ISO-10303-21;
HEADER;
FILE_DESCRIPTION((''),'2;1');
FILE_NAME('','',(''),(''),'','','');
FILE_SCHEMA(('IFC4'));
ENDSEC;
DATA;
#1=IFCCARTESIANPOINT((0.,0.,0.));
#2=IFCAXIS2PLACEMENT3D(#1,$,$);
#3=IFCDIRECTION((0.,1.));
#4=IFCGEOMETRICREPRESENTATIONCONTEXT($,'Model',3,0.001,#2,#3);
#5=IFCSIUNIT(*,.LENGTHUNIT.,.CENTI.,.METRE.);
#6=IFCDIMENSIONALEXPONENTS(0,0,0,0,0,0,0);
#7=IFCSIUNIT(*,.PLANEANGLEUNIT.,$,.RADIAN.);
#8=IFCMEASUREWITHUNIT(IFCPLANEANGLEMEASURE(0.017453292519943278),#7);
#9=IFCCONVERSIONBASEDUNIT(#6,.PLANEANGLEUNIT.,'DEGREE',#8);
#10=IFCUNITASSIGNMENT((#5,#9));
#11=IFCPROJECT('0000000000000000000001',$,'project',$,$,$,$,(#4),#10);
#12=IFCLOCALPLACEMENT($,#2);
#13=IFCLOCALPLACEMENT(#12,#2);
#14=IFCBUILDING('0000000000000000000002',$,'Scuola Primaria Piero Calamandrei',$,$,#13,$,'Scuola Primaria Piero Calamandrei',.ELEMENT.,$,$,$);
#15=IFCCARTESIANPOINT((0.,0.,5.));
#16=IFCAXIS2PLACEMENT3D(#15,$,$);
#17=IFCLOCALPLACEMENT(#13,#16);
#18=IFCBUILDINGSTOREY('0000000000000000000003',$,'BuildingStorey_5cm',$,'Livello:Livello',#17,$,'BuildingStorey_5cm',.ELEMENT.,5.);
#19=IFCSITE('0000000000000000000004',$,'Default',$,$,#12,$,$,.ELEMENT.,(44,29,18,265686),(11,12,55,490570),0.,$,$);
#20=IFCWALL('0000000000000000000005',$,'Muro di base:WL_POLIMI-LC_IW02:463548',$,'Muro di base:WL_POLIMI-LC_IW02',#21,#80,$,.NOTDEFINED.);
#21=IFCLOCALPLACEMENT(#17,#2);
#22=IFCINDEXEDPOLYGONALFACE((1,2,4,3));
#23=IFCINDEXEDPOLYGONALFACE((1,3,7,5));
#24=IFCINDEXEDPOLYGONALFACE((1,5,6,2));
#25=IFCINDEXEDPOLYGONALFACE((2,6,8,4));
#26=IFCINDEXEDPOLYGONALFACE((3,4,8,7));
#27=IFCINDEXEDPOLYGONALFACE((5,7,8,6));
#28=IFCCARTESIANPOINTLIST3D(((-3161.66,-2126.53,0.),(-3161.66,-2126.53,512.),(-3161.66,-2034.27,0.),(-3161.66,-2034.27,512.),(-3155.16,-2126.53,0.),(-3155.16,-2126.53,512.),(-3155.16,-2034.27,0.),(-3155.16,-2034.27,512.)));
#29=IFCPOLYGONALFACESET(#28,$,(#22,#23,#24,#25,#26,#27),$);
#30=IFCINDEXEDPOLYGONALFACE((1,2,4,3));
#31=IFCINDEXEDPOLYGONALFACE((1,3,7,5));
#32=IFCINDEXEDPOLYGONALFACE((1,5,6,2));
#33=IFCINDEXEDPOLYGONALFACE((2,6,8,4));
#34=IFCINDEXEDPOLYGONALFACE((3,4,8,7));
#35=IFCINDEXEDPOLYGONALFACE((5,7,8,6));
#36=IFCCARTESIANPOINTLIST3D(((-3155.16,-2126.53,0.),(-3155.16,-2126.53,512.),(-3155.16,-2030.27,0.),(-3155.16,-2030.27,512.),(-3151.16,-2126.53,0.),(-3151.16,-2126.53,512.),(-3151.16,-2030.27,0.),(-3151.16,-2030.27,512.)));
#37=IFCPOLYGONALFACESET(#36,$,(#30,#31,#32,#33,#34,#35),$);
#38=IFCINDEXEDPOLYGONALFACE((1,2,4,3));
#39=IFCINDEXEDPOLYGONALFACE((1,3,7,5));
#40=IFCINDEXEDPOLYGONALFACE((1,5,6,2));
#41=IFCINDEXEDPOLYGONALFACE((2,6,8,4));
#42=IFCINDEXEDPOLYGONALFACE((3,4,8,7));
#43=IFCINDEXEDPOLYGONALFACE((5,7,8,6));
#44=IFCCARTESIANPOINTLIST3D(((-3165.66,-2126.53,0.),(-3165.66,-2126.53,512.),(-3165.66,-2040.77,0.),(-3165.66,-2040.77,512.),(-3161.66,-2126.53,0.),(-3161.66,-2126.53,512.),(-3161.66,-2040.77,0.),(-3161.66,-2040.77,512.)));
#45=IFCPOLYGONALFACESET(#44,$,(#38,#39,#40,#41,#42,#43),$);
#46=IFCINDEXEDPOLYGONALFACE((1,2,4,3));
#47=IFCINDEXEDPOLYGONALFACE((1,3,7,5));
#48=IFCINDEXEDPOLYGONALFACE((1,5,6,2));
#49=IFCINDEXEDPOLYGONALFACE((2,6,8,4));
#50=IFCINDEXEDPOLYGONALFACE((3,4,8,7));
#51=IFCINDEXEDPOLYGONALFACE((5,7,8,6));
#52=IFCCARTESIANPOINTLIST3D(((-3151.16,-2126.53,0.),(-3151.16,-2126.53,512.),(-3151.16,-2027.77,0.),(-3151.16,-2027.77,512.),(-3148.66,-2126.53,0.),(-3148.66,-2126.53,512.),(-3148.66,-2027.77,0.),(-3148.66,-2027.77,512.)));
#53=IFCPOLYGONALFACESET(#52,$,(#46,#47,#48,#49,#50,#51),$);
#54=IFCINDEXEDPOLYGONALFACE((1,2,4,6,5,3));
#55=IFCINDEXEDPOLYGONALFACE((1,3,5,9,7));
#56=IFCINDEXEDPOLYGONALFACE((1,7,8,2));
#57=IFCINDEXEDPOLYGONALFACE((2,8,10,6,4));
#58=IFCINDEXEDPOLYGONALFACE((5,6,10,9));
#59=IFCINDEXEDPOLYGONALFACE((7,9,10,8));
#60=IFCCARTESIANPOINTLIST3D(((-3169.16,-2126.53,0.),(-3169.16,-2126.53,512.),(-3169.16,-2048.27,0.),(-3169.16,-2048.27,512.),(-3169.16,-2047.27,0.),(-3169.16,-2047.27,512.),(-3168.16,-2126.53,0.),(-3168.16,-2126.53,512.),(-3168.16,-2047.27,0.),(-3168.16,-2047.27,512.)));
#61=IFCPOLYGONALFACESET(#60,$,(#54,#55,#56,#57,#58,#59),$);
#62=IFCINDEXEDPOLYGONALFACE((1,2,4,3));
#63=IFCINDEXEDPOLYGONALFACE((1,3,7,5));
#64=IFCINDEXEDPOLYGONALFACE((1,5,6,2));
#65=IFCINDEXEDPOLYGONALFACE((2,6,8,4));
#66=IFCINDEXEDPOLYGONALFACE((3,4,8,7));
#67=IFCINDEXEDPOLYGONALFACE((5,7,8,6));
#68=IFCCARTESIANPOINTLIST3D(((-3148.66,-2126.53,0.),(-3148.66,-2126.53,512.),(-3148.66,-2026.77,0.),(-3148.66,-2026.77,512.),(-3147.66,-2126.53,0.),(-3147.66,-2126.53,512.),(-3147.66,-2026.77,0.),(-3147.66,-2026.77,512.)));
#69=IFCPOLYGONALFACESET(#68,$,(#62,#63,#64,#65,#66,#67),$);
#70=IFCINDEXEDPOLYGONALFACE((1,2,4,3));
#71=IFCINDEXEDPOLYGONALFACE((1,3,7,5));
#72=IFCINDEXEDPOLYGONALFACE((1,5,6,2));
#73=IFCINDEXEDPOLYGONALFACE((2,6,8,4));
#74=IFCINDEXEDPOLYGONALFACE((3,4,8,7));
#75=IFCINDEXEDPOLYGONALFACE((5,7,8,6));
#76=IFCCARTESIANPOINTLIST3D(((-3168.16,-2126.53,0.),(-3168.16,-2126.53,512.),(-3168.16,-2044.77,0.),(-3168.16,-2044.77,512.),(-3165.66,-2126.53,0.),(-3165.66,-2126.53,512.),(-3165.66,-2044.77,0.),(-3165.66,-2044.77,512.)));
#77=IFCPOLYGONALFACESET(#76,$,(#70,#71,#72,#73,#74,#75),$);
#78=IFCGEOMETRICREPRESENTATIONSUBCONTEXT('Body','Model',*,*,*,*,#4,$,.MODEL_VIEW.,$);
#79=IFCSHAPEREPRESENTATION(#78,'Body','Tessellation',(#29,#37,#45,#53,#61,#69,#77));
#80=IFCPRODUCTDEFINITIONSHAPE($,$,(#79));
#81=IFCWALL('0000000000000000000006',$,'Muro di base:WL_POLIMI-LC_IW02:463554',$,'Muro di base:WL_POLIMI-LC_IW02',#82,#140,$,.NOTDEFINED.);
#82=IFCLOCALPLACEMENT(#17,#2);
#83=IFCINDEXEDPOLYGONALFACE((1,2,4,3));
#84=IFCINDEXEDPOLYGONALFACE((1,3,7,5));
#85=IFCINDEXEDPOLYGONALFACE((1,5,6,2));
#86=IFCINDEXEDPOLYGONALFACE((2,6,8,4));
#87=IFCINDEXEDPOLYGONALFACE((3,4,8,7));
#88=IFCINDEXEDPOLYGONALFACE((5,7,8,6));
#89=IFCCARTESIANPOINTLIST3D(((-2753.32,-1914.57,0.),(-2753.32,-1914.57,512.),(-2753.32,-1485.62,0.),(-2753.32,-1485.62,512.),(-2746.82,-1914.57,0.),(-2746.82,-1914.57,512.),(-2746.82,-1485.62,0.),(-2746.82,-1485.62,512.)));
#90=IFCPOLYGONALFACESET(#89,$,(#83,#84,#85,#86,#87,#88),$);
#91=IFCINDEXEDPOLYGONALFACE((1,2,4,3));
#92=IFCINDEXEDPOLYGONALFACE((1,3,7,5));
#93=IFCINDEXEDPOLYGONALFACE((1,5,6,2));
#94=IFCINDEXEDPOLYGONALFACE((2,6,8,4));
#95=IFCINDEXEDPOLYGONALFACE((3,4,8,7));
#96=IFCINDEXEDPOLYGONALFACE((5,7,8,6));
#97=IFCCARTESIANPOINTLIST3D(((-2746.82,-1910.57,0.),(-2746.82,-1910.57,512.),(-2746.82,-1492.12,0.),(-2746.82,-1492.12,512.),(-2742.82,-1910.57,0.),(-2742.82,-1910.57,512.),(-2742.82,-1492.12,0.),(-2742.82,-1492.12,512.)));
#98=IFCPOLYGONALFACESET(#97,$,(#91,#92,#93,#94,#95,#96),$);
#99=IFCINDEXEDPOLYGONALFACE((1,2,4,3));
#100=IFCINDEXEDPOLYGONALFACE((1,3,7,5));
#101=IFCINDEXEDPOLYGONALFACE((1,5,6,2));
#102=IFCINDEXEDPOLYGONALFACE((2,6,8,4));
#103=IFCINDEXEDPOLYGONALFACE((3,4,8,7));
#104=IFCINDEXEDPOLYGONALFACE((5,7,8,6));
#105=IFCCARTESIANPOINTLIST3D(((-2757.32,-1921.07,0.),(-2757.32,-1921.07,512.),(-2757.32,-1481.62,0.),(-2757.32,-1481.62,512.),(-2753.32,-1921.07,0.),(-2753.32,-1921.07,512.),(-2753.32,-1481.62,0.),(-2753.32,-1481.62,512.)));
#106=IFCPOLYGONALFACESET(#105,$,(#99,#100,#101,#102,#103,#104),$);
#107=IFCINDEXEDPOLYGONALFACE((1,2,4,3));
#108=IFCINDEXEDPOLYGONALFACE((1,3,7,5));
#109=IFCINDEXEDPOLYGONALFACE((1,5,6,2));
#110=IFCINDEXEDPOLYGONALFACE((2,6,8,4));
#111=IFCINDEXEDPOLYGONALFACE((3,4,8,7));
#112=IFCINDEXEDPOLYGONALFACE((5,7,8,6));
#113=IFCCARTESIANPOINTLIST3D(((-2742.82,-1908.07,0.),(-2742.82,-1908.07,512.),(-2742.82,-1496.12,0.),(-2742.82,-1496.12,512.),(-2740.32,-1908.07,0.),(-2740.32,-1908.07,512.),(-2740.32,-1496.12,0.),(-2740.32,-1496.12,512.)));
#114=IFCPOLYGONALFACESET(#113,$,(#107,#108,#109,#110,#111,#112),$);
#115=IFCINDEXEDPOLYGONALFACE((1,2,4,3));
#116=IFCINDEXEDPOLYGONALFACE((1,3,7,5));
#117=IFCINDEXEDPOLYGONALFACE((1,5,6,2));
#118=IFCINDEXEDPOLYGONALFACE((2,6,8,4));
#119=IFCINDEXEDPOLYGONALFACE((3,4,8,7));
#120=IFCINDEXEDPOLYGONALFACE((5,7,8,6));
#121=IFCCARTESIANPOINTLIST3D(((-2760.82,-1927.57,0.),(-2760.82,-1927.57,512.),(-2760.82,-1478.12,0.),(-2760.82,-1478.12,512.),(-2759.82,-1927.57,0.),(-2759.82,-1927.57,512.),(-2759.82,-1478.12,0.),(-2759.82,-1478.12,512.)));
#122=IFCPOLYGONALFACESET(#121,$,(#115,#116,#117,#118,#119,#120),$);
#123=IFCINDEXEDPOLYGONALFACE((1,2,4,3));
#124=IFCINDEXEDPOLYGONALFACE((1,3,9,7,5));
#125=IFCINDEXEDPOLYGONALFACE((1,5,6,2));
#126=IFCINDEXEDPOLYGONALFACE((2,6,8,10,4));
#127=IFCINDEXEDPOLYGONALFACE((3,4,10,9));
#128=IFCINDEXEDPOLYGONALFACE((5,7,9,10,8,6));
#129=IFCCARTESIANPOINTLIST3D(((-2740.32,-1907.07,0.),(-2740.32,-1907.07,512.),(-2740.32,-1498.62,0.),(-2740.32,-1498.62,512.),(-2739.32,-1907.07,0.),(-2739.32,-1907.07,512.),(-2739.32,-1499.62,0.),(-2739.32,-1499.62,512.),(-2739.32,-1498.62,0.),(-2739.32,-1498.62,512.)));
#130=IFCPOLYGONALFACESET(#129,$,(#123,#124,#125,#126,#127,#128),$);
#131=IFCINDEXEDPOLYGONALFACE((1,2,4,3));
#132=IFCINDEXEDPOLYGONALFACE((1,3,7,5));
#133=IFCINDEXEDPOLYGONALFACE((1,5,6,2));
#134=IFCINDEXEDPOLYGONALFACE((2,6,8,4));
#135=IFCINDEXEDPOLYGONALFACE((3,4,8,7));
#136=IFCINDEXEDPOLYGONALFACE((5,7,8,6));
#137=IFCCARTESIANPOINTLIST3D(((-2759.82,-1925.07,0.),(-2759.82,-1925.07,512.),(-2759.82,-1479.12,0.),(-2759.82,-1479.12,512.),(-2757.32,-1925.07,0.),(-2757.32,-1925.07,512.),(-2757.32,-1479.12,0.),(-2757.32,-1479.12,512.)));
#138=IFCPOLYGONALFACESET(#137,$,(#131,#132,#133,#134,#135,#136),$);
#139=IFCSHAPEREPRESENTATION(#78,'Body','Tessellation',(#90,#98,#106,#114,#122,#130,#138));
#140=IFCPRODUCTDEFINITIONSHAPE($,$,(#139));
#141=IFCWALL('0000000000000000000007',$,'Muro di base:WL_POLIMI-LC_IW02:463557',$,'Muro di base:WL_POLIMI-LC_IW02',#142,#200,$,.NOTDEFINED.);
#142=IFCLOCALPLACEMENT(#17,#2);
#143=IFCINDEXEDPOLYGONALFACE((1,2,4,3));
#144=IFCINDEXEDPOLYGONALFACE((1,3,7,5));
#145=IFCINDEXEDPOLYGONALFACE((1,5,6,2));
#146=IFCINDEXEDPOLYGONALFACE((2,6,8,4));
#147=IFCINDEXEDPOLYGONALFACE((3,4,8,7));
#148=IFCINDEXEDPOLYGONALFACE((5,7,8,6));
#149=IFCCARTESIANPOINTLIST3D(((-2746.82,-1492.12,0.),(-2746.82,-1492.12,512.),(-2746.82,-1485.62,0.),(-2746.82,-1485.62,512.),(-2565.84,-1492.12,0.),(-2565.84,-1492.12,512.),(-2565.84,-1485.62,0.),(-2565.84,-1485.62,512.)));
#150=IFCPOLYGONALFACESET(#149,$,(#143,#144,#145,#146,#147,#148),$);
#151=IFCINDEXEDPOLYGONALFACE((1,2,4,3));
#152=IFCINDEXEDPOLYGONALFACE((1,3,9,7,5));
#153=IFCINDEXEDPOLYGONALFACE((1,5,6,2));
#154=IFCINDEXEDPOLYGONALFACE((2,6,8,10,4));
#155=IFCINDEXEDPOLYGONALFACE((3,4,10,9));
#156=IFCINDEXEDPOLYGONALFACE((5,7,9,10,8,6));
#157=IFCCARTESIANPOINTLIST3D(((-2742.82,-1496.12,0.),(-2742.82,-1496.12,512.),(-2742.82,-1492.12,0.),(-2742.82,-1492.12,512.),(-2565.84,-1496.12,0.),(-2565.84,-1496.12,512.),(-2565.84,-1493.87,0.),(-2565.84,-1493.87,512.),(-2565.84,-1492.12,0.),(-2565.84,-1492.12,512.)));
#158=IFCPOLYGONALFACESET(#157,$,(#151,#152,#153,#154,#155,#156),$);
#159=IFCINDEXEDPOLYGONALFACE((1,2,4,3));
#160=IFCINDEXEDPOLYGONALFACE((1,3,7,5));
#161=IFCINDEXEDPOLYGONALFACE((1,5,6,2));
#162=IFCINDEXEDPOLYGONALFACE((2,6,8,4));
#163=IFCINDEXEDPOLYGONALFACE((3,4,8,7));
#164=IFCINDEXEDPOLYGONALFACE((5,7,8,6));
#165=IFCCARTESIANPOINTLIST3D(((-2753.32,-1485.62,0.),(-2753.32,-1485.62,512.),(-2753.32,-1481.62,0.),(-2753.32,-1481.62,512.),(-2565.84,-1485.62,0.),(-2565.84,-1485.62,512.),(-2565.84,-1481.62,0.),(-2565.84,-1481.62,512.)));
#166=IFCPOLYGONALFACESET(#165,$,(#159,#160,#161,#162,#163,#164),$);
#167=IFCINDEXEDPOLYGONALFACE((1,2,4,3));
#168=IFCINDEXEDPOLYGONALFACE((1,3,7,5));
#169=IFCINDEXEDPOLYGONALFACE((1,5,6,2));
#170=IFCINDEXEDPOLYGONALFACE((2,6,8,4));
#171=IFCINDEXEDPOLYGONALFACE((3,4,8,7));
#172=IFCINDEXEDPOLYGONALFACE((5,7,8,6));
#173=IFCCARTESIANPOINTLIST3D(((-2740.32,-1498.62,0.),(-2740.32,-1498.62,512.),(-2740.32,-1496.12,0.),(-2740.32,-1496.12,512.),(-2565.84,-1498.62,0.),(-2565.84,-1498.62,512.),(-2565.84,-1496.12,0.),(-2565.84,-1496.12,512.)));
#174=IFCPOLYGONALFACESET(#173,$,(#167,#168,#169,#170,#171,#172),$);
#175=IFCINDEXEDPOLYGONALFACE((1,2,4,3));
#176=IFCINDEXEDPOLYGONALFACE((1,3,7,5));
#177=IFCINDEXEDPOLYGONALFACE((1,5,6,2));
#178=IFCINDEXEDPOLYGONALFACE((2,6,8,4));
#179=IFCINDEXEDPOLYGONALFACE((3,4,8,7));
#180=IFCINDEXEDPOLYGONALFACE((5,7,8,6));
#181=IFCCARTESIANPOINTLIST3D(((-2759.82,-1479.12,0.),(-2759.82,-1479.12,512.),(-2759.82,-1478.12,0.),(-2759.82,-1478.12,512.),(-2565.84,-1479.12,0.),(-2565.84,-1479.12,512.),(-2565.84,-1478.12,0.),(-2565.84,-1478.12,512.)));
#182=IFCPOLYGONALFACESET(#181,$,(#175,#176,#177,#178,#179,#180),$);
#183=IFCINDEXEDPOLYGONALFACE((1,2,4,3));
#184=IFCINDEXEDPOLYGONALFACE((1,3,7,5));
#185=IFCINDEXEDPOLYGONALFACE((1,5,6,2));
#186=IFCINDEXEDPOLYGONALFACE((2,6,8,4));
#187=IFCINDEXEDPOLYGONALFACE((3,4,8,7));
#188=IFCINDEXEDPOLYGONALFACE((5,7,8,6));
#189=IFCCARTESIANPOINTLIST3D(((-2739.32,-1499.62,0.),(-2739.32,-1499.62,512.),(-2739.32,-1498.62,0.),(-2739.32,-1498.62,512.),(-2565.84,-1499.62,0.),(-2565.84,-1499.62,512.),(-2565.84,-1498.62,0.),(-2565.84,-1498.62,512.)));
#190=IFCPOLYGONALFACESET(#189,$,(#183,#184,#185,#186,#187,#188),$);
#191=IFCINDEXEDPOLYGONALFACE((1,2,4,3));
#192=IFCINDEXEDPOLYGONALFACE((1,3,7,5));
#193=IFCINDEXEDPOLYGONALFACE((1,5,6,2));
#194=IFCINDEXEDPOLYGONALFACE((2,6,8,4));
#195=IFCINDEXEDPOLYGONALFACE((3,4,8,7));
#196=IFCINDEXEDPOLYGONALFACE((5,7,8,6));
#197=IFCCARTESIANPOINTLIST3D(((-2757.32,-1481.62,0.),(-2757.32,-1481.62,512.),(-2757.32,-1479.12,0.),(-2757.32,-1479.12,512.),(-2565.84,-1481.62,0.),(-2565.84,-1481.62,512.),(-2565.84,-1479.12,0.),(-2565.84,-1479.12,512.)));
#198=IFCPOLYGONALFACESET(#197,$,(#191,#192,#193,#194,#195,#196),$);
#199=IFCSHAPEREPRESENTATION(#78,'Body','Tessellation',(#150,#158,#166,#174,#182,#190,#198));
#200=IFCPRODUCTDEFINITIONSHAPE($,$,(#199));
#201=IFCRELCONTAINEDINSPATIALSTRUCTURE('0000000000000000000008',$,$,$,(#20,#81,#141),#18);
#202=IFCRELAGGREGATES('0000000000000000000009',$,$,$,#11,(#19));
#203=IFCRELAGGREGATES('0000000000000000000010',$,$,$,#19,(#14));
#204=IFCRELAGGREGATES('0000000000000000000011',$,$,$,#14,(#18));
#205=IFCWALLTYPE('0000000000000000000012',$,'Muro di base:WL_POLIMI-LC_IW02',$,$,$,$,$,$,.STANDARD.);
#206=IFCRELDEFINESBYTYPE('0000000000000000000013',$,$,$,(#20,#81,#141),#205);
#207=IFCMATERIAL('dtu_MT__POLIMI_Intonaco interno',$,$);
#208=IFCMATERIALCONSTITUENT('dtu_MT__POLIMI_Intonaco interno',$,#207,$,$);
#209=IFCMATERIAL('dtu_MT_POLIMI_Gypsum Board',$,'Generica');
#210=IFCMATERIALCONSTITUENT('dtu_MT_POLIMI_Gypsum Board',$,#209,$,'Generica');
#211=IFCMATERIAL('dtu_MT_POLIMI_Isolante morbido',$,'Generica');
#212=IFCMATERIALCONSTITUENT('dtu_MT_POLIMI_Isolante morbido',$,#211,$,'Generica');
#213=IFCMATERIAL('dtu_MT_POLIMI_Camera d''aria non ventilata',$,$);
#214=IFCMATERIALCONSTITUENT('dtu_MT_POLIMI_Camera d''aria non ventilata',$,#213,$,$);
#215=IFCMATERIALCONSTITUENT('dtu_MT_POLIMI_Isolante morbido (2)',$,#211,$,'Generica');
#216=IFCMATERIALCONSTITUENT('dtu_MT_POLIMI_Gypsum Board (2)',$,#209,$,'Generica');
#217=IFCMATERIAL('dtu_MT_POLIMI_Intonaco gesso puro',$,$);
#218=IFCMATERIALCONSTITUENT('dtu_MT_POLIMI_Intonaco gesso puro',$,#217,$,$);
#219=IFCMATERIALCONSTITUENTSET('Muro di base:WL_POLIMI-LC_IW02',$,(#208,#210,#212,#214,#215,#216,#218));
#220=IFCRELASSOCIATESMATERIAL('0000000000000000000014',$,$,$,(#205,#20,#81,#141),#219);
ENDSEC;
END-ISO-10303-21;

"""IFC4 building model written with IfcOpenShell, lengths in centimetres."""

from ifc_helpers import new_model, entity, si_unit, converted_unit, direction, frame, origin, place, context, subcontext, project, spatial, indexed_curve, outline, extrude, material, constituent, constituent_set, type_object, element, save


model = new_model("IFC4")

# Units and contexts
model_context = context("Model", 3, precision=0.001, world=origin(), true_north=direction((0.0, 1.0)))
body_context = subcontext(model_context, "Body", "Model", "MODEL_VIEW")
ifc_project = project(units=[si_unit("LENGTHUNIT", "METRE", prefix="CENTI"), converted_unit("PLANEANGLEUNIT", "DEGREE", entity("IfcPlaneAngleMeasure", 0.017453292519943278), si_unit("PLANEANGLEUNIT", "RADIAN"), dimensions=[0, 0, 0, 0, 0, 0, 0])], contexts=[model_context])

# Site, building, storey
site_placement = place(None, origin())
site = spatial("IfcSite", under=ifc_project, at=site_placement, Name="Default", CompositionType="ELEMENT", RefLatitude=(44, 29, 18, 265686), RefLongitude=(11, 12, 55, 490570), RefElevation=0.0)
building_placement = place(site_placement, origin())
building = spatial("IfcBuilding", under=site, at=building_placement, Name="Scuola Primaria Piero Calamandrei", LongName="Scuola Primaria Piero Calamandrei", CompositionType="ELEMENT")
storey_placement = place(building_placement, frame((0.0, 0.0, 5.0)))
storey = spatial("IfcBuildingStorey", under=building, at=storey_placement, Name="BuildingStorey_5cm", ObjectType="Livello:Livello", LongName="BuildingStorey_5cm", CompositionType="ELEMENT", Elevation=5.0)

# Shared definitions
ifc_material_1 = material(Name="dtu_MT_POLIMI_Intonaco gesso puro")

# Shared definitions
ifc_material_2 = material(Name="dtu_MT__POLIMI_Intonaco interno")

# Shared definitions
ifc_constituent_1 = constituent(ifc_material_2, Name="dtu_MT__POLIMI_Intonaco interno")
ifc_material_3 = material(Name="dtu_MT_POLIMI_Gypsum Board", Category="Generica")
ifc_constituent_2 = constituent(ifc_material_3, Name="dtu_MT_POLIMI_Gypsum Board", Category="Generica")
ifc_material_4 = material(Name="dtu_MT_POLIMI_Isolante morbido", Category="Generica")
ifc_constituent_3 = constituent(ifc_material_4, Name="dtu_MT_POLIMI_Isolante morbido", Category="Generica")
ifc_material_5 = material(Name="dtu_MT_POLIMI_Camera d'aria non ventilata")
ifc_constituent_4 = constituent(ifc_material_5, Name="dtu_MT_POLIMI_Camera d'aria non ventilata")
ifc_constituent_5 = constituent(ifc_material_4, Name="dtu_MT_POLIMI_Isolante morbido (2)", Category="Generica")
ifc_constituent_6 = constituent(ifc_material_3, Name="dtu_MT_POLIMI_Gypsum Board (2)", Category="Generica")
ifc_constituent_7 = constituent(ifc_material_1, Name="dtu_MT_POLIMI_Intonaco gesso puro")
ifc_constituent_set_1 = constituent_set(constituents=[ifc_constituent_1, ifc_constituent_2, ifc_constituent_3, ifc_constituent_4, ifc_constituent_5, ifc_constituent_6, ifc_constituent_7], Name="Muro di base:WL_POLIMI-LC_IW02")
wall_type_1 = type_object("IfcWallType", Name="Muro di base:WL_POLIMI-LC_IW02", PredefinedType="STANDARD", material=ifc_constituent_set_1)

# Wall
wall_1_placement = place(storey_placement, frame((-3158.41, -2026.77, 0.0), z_axis=(0.0, 0.0, 1.0), x_axis=(0.0, -1.0, 0.0)))
element("IfcWall", 1, at=wall_1_placement, inside=storey, type_object=wall_type_1, material=ifc_constituent_set_1, Name="Muro di base:WL_POLIMI-LC_IW02:463548", ObjectType="Muro di base:WL_POLIMI-LC_IW02", PredefinedType="NOTDEFINED", context=body_context, shape_type="SweptSolid", body=[
    extrude(outline(indexed_curve([(-46.13, -3.25), (46.13, -3.25), (46.13, 3.25), (-46.13, 3.25), (-46.13, -3.25)], self_intersect=False)), frame((53.63, 0.0, 0.0)), (0.0, 0.0, 1.0), 512.0),
    extrude(outline(indexed_curve([(-48.13, -2.0), (48.13, -2.0), (48.13, 2.0), (-48.13, 2.0), (-48.13, -2.0)], self_intersect=False)), frame((51.63, 5.25, 0.0)), (0.0, 0.0, 1.0), 512.0),
    extrude(outline(indexed_curve([(-42.88, -2.0), (42.88, -2.0), (42.88, 2.0), (-42.88, 2.0), (-42.88, -2.0)], self_intersect=False)), frame((56.88, -5.25, 0.0)), (0.0, 0.0, 1.0), 512.0),
    extrude(outline(indexed_curve([(-49.38, -1.25), (49.38, -1.25), (49.38, 1.25), (-49.38, 1.25), (-49.38, -1.25)], self_intersect=False)), frame((50.38, 8.5, 0.0)), (0.0, 0.0, 1.0), 512.0),
    extrude(outline(indexed_curve([(-30.9, -0.4), (47.35, -0.4), (47.35, 0.6), (-31.9, 0.6), (-31.9, -0.4), (-30.9, -0.4)], self_intersect=False)), frame((52.4, -10.35, 0.0)), (0.0, 0.0, 1.0), 512.0),
    extrude(outline(indexed_curve([(-0.5, -49.88), (0.5, -49.88), (0.5, 49.88), (-0.5, 49.88), (-0.5, -49.88)], self_intersect=False)), frame((49.88, 10.25, 0.0), z_axis=(0.0, 0.0, 1.0), x_axis=(0.0, -1.0, 0.0)), (0.0, 0.0, 1.0), 512.0),
    extrude(outline(indexed_curve([(-40.88, -1.25), (40.88, -1.25), (40.88, 1.25), (-40.88, 1.25), (-40.88, -1.25)], self_intersect=False)), frame((58.88, -8.5, 0.0)), (0.0, 0.0, 1.0), 512.0),
])

# Walls
wall_2_placement = place(storey_placement, frame((-2750.07, -1478.12, 0.0), z_axis=(0.0, 0.0, 1.0), x_axis=(0.0, -1.0, 0.0)))
element("IfcWall", 2, at=wall_2_placement, inside=storey, type_object=wall_type_1, material=ifc_constituent_set_1, Name="Muro di base:WL_POLIMI-LC_IW02:463554", ObjectType="Muro di base:WL_POLIMI-LC_IW02", PredefinedType="NOTDEFINED", context=body_context, shape_type="SweptSolid", body=[
    extrude(outline(indexed_curve([(-214.47, -3.25), (214.47, -3.25), (214.47, 3.25), (-214.47, 3.25), (-214.47, -3.25)], self_intersect=False)), frame((221.97, 0.0, 0.0)), (0.0, 0.0, 1.0), 512.0),
    extrude(outline(indexed_curve([(-209.22, -2.0), (209.22, -2.0), (209.22, 2.0), (-209.22, 2.0), (-209.22, -2.0)], self_intersect=False)), frame((223.22, 5.25, 0.0)), (0.0, 0.0, 1.0), 512.0),
    extrude(outline(indexed_curve([(-219.72, -2.0), (219.72, -2.0), (219.72, 2.0), (-219.72, 2.0), (-219.72, -2.0)], self_intersect=False)), frame((223.22, -5.25, 0.0)), (0.0, 0.0, 1.0), 512.0),
    extrude(outline(indexed_curve([(-205.97, -1.25), (205.97, -1.25), (205.97, 1.25), (-205.97, 1.25), (-205.97, -1.25)], self_intersect=False)), frame((223.97, 8.5, 0.0)), (0.0, 0.0, 1.0), 512.0),
    extrude(outline(indexed_curve([(-0.5, -224.72), (0.5, -224.72), (0.5, 224.72), (-0.5, 224.72), (-0.5, -224.72)], self_intersect=False)), frame((224.72, -10.25, 0.0), z_axis=(0.0, 0.0, 1.0), x_axis=(0.0, 1.0, 0.0)), (0.0, 0.0, 1.0), 512.0),
    extrude(outline(indexed_curve([(162.58, -0.4), (163.58, -0.4), (163.58, 0.6), (-244.87, 0.6), (-244.87, -0.4), (162.58, -0.4)], self_intersect=False)), frame((184.08, 10.35, 0.0), z_axis=(0.0, 0.0, 1.0), x_axis=(-1.0, 0.0, 0.0)), (0.0, 0.0, 1.0), 512.0),
    extrude(outline(indexed_curve([(-222.97, -1.25), (222.97, -1.25), (222.97, 1.25), (-222.97, 1.25), (-222.97, -1.25)], self_intersect=False)), frame((223.97, -8.5, 0.0)), (0.0, 0.0, 1.0), 512.0),
])
wall_3_placement = place(storey_placement, frame((-2565.84, -1488.87, 0.0), z_axis=(0.0, 0.0, 1.0), x_axis=(-1.0, 0.0, 0.0)))
element("IfcWall", 3, at=wall_3_placement, inside=storey, type_object=wall_type_1, material=ifc_constituent_set_1, Name="Muro di base:WL_POLIMI-LC_IW02:463557", ObjectType="Muro di base:WL_POLIMI-LC_IW02", PredefinedType="NOTDEFINED", context=body_context, shape_type="SweptSolid", body=[
    extrude(outline(indexed_curve([(-90.49, -3.25), (90.49, -3.25), (90.49, 3.25), (-90.49, 3.25), (-90.49, -3.25)], self_intersect=False)), frame((90.49, 0.0, 0.0)), (0.0, 0.0, 1.0), 512.0),
    extrude(outline(indexed_curve([(-70.79, -1.95), (106.19, -1.95), (106.19, 2.05), (-70.79, 2.05), (-70.79, -0.2), (-70.79, -1.95)], self_intersect=False)), frame((70.79, 5.2, 0.0)), (0.0, 0.0, 1.0), 512.0),
    extrude(outline(indexed_curve([(-93.74, -2.0), (93.74, -2.0), (93.74, 2.0), (-93.74, 2.0), (-93.74, -2.0)], self_intersect=False)), frame((93.74, -5.25, 0.0)), (0.0, 0.0, 1.0), 512.0),
    extrude(outline(indexed_curve([(-87.24, -1.25), (87.24, -1.25), (87.24, 1.25), (-87.24, 1.25), (-87.24, -1.25)], self_intersect=False)), frame((87.24, 8.5, 0.0)), (0.0, 0.0, 1.0), 512.0),
    extrude(outline(indexed_curve([(-0.5, -96.99), (0.5, -96.99), (0.5, 96.99), (-0.5, 96.99), (-0.5, -96.99)], self_intersect=False)), frame((96.99, -10.25, 0.0), z_axis=(0.0, 0.0, 1.0), x_axis=(0.0, 1.0, 0.0)), (0.0, 0.0, 1.0), 512.0),
    extrude(outline(indexed_curve([(-0.5, -86.74), (0.5, -86.74), (0.5, 86.74), (-0.5, 86.74), (-0.5, -86.74)], self_intersect=False)), frame((86.74, 10.25, 0.0), z_axis=(0.0, 0.0, 1.0), x_axis=(0.0, -1.0, 0.0)), (0.0, 0.0, 1.0), 512.0),
    extrude(outline(indexed_curve([(-95.74, -1.25), (95.74, -1.25), (95.74, 1.25), (-95.74, 1.25), (-95.74, -1.25)], self_intersect=False)), frame((95.74, -8.5, 0.0)), (0.0, 0.0, 1.0), 512.0),
])

save(model, "model.ifc")
